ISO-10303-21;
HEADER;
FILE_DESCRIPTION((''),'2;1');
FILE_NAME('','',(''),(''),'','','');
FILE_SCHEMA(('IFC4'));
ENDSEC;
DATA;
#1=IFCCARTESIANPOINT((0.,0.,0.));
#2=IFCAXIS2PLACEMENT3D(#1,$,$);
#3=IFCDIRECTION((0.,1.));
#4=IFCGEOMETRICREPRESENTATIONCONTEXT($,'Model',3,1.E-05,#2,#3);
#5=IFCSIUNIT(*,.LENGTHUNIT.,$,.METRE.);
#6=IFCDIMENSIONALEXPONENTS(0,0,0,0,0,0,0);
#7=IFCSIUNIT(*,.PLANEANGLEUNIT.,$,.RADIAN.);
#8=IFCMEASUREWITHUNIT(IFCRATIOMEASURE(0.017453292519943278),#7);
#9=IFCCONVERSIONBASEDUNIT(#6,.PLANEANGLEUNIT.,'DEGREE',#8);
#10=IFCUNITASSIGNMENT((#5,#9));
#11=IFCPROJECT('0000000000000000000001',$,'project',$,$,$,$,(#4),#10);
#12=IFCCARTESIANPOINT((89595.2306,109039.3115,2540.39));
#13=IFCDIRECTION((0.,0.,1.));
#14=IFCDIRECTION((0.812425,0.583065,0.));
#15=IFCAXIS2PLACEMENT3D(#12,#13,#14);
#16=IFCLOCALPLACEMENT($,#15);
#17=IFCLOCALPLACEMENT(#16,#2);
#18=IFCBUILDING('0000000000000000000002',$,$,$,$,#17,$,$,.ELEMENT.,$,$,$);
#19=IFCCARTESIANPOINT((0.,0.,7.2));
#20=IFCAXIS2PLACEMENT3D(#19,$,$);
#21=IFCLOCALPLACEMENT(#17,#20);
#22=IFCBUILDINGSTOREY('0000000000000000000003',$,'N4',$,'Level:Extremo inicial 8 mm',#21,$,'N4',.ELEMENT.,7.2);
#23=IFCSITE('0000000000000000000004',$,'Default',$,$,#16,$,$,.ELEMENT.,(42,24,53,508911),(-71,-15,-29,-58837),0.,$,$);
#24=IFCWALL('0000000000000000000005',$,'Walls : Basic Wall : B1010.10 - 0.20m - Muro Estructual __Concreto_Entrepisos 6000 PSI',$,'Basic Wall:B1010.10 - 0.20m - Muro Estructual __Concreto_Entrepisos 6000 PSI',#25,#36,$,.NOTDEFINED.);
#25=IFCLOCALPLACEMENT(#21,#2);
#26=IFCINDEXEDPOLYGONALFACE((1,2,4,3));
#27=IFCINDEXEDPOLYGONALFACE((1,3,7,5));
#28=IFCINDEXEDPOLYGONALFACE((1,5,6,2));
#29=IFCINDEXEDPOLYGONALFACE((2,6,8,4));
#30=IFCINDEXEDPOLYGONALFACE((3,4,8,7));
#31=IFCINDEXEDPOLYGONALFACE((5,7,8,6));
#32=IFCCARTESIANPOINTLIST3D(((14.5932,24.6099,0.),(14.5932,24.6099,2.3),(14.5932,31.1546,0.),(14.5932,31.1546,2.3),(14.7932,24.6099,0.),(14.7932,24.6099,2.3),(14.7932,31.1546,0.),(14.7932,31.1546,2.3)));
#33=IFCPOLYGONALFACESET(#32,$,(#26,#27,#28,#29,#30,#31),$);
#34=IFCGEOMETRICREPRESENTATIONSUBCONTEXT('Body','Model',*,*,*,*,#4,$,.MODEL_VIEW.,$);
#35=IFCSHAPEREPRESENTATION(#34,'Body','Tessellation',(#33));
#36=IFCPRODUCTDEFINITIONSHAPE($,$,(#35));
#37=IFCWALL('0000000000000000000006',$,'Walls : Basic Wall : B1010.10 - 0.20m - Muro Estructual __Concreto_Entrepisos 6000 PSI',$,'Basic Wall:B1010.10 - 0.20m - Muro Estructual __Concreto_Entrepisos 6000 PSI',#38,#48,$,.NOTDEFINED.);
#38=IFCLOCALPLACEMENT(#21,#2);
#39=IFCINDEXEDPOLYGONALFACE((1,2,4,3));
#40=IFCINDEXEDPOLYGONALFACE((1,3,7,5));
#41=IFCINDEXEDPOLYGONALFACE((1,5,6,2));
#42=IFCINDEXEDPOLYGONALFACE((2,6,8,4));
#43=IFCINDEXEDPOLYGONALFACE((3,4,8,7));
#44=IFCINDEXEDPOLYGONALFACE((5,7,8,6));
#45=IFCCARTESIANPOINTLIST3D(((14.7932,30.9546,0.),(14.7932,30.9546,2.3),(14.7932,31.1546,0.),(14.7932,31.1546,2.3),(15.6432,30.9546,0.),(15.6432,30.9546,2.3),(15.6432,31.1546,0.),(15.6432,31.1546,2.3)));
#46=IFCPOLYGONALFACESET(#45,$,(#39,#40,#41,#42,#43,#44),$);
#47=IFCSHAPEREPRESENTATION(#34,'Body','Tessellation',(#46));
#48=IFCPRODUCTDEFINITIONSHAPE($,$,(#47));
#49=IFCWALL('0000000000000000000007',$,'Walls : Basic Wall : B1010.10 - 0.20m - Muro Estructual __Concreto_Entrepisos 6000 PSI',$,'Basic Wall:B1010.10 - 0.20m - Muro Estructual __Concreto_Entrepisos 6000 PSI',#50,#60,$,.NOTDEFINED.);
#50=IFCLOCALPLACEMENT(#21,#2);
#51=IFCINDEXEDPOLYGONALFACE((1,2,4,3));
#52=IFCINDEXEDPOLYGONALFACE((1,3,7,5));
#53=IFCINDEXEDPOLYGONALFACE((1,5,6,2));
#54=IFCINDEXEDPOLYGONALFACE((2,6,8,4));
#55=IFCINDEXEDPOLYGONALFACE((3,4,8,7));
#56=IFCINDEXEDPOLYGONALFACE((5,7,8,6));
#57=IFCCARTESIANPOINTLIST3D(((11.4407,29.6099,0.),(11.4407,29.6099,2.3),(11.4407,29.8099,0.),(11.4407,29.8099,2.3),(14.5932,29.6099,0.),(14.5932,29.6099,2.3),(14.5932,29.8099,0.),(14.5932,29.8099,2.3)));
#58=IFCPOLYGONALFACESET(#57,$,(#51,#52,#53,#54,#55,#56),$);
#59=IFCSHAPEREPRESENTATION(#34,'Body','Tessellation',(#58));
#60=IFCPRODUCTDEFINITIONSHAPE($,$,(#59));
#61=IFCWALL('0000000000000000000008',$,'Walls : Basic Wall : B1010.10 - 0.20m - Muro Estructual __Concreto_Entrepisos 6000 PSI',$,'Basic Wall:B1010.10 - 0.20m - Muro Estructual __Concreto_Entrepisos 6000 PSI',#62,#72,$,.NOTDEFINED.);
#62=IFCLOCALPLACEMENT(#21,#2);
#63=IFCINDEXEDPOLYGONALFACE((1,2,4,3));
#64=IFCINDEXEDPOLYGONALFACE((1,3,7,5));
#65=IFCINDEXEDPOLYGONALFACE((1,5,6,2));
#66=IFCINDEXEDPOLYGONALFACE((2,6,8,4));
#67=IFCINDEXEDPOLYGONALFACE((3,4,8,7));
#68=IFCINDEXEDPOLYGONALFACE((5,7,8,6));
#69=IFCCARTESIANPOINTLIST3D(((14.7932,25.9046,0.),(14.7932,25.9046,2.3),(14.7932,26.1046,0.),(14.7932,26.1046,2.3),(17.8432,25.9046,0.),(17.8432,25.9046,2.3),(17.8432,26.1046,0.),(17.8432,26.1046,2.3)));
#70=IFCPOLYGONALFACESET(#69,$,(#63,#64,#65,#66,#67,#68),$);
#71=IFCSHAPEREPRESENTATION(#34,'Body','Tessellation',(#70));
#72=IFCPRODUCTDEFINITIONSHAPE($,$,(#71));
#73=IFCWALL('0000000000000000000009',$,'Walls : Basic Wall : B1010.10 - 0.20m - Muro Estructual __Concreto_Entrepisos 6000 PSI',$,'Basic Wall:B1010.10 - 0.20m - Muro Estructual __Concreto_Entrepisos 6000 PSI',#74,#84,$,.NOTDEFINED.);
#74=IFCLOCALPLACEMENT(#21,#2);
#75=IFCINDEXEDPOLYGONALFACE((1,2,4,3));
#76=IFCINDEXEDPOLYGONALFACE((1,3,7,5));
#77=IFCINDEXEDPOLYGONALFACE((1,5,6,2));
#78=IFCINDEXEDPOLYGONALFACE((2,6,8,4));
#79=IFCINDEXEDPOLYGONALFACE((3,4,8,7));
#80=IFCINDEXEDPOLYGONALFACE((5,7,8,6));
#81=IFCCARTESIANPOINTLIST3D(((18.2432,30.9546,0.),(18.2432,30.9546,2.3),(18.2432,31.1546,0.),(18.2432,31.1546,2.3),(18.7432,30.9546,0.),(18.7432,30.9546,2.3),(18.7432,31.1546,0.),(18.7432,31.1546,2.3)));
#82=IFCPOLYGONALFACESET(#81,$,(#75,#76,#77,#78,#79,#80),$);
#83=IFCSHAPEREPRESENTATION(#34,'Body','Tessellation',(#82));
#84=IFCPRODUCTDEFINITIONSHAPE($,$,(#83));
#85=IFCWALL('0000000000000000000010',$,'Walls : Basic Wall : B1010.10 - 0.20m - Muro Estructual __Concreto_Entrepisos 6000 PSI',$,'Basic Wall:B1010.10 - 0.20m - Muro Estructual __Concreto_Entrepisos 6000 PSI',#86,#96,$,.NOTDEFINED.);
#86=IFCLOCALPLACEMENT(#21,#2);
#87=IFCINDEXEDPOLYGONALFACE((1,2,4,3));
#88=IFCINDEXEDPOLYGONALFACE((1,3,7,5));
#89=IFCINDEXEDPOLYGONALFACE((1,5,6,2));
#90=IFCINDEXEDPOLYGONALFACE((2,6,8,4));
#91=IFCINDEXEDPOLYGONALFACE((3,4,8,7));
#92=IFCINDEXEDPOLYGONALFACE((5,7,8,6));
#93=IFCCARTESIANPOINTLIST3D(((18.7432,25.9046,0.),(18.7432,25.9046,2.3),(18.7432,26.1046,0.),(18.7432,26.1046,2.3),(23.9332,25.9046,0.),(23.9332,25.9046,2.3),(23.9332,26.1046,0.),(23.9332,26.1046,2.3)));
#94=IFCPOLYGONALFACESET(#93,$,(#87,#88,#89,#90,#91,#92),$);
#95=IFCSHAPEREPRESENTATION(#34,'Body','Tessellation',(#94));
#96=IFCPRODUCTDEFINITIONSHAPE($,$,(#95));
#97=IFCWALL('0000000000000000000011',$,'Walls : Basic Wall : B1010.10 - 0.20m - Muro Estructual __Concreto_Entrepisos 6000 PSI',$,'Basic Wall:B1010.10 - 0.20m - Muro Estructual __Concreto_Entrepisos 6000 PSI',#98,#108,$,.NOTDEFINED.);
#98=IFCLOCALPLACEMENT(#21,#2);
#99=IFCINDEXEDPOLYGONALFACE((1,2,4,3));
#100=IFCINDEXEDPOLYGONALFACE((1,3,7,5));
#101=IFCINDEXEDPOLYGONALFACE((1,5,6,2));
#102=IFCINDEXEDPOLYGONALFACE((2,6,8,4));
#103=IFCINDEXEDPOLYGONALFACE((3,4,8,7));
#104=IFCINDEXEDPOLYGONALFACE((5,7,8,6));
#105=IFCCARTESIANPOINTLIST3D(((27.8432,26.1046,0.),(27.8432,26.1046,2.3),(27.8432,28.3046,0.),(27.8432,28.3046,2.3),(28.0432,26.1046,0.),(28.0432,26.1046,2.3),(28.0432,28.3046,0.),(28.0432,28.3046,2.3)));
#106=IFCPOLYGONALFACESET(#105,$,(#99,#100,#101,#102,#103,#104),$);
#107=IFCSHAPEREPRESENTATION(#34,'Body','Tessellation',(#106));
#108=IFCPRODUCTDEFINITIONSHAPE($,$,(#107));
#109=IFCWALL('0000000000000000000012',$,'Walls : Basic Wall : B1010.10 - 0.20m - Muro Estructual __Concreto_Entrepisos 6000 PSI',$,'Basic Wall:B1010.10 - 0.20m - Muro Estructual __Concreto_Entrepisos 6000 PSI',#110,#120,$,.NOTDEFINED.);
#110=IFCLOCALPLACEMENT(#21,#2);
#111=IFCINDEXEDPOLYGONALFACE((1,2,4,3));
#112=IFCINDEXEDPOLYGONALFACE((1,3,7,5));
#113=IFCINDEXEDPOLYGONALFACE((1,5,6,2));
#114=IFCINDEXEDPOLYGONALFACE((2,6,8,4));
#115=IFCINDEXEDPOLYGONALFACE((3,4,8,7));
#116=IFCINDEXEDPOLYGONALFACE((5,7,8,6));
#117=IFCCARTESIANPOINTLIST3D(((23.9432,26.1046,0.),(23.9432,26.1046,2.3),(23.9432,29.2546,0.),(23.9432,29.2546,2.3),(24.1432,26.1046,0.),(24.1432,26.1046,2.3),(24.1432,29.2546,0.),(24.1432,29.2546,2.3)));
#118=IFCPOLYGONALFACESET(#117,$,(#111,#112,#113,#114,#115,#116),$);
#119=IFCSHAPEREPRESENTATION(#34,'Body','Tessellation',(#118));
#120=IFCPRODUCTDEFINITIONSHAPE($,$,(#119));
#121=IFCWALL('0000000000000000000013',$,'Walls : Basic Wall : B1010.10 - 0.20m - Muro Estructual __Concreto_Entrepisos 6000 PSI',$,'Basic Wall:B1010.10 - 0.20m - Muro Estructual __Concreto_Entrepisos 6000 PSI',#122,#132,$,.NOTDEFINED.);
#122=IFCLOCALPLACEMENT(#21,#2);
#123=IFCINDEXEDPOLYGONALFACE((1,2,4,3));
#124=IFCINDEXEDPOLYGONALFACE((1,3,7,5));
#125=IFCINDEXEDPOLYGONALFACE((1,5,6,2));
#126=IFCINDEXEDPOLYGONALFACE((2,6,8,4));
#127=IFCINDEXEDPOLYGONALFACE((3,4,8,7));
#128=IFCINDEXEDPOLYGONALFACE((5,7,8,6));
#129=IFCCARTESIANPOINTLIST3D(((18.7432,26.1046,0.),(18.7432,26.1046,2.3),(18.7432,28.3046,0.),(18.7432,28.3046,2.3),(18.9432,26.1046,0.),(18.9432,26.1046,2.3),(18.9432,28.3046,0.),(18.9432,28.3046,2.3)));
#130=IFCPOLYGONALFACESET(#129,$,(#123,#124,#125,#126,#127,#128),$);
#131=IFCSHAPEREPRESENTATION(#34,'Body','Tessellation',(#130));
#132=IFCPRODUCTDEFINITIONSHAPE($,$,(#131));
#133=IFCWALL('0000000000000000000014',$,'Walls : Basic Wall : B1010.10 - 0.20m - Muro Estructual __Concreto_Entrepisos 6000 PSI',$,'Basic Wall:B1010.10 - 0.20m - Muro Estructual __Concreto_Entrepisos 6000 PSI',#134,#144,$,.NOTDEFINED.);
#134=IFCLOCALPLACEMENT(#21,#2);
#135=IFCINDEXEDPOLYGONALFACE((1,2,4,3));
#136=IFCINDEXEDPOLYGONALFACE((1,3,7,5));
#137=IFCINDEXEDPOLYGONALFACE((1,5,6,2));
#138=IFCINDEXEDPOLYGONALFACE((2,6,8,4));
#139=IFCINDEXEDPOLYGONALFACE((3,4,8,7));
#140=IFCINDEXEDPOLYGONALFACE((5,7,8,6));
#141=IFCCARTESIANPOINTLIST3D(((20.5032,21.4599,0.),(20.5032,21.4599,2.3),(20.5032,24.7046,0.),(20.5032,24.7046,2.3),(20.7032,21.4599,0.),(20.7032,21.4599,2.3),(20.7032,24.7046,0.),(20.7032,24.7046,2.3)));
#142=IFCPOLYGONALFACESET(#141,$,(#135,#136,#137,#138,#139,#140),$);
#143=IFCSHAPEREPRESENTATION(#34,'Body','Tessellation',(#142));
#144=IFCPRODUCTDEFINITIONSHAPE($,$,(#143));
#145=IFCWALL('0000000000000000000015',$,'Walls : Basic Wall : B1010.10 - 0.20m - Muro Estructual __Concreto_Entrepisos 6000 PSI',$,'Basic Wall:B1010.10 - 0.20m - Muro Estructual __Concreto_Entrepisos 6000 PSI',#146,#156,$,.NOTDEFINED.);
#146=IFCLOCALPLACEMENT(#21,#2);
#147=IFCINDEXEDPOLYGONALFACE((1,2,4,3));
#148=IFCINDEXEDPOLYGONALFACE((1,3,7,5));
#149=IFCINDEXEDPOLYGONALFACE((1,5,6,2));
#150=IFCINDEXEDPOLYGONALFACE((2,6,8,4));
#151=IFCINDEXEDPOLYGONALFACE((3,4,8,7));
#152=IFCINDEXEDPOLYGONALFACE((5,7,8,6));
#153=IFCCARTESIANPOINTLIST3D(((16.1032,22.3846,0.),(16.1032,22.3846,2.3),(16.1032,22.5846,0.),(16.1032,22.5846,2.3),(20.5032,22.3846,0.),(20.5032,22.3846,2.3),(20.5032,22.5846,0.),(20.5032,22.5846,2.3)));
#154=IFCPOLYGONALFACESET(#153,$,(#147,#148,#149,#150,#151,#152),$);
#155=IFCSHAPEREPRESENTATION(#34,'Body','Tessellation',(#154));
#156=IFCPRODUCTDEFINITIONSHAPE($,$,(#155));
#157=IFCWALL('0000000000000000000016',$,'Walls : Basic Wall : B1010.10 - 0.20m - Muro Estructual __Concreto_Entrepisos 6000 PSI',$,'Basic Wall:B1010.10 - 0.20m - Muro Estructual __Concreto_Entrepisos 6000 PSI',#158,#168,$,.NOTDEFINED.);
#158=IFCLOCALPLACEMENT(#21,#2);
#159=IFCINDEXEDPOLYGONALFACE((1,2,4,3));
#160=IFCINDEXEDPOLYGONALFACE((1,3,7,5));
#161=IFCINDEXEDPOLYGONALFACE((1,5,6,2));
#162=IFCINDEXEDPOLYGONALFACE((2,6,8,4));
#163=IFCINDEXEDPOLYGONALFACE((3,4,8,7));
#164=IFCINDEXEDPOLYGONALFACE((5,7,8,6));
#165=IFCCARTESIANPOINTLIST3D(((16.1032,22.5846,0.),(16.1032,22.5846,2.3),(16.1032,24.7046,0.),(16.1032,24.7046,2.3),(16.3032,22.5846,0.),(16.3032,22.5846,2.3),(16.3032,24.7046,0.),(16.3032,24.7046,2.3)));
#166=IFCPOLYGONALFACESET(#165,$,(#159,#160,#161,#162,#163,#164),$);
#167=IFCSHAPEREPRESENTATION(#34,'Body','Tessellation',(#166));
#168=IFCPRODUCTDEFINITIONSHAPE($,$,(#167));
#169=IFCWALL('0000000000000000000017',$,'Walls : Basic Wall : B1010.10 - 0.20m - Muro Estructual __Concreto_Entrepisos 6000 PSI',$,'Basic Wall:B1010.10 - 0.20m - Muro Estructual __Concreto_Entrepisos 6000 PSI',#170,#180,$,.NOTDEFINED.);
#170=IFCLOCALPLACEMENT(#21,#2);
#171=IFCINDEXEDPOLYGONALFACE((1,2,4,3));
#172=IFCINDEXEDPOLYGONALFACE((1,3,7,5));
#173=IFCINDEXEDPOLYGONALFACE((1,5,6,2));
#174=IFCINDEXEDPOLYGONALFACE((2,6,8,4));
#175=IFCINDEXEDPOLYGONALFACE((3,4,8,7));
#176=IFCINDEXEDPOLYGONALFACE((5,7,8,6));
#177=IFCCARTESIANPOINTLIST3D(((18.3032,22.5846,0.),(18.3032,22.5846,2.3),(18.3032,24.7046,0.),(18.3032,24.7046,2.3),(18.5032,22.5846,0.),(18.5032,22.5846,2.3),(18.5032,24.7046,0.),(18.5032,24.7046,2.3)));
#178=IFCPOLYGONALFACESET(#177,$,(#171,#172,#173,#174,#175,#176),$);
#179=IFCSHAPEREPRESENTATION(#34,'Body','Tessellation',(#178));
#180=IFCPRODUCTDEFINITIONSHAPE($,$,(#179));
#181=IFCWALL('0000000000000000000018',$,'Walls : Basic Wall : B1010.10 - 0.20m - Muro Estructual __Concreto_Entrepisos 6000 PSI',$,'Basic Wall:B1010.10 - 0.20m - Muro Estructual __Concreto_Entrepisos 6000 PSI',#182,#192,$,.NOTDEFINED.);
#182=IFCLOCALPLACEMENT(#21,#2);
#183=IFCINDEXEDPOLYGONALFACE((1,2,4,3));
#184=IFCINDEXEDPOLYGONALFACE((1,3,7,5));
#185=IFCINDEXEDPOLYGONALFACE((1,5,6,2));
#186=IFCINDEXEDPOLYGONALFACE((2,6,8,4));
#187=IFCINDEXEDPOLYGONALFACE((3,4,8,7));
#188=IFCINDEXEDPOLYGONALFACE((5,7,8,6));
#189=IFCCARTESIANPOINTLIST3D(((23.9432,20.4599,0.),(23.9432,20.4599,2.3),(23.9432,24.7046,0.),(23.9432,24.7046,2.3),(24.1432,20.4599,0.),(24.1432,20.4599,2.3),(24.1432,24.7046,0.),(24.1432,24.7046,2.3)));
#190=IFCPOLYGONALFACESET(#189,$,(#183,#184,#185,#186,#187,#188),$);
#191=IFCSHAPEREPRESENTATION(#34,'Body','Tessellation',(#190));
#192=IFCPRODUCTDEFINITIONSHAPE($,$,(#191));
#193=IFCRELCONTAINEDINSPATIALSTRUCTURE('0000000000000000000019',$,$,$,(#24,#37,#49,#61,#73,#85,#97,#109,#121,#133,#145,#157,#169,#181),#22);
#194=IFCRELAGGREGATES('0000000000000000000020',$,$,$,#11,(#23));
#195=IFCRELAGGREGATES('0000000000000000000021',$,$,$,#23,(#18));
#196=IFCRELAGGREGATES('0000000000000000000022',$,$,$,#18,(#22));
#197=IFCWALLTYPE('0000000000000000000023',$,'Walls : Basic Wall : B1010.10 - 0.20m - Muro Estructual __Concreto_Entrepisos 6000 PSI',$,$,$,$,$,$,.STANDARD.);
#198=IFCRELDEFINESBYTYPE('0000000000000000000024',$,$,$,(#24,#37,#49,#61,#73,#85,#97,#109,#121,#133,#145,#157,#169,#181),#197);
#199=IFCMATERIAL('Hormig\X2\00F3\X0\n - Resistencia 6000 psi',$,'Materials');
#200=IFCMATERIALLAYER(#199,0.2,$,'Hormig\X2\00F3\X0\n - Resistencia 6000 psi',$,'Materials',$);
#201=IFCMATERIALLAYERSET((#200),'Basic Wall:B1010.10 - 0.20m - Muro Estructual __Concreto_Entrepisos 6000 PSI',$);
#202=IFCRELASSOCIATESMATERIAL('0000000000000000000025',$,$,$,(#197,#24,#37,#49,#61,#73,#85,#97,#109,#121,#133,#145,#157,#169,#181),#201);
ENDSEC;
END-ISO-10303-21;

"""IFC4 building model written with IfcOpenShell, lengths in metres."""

from ifc_helpers import new_model, entity, si_unit, converted_unit, direction, frame, frame_2d, origin, place, context, subcontext, project, spatial, rectangle, extrude, material, layer, layer_set, layer_usage, type_object, element, save


model = new_model("IFC4")

# Units and contexts
model_context = context("Model", 3, precision=1e-05, world=origin(), true_north=direction((0.0, 1.0)))
body_context = subcontext(model_context, "Body", "Model", "MODEL_VIEW")
ifc_project = project(units=[si_unit("LENGTHUNIT", "METRE"), converted_unit("PLANEANGLEUNIT", "DEGREE", entity("IfcRatioMeasure", 0.017453292519943278), si_unit("PLANEANGLEUNIT", "RADIAN"), dimensions=[0, 0, 0, 0, 0, 0, 0])], contexts=[model_context])

# Site, building, storey
site_placement = place(None, frame((89595.2306, 109039.3115, 2540.39), z_axis=(0.0, 0.0, 1.0), x_axis=(0.812425, 0.583065, 0.0)))
site = spatial("IfcSite", under=ifc_project, at=site_placement, Name="Default", CompositionType="ELEMENT", RefLatitude=(42, 24, 53, 508911), RefLongitude=(-71, -15, -29, -58837), RefElevation=0.0)
building_placement = place(site_placement, origin())
building = spatial("IfcBuilding", under=site, at=building_placement, CompositionType="ELEMENT")
storey_placement = place(building_placement, frame((0.0, 0.0, 7.2)))
storey = spatial("IfcBuildingStorey", under=building, at=storey_placement, Name="N4", ObjectType="Level:Extremo inicial 8 mm", LongName="N4", CompositionType="ELEMENT", Elevation=7.2)

# Walls
ifc_material_1 = material(Name="Hormigón - Resistencia 6000 psi", Category="Materials")
ifc_layer_1 = layer(ifc_material_1, 0.2, Name="Hormigón - Resistencia 6000 psi", Category="Materials")
ifc_layer_set_1 = layer_set([ifc_layer_1], Name="Basic Wall:B1010.10 - 0.20m - Muro Estructual __Concreto_Entrepisos 6000 PSI")
ifc_layer_usage_1 = layer_usage(ifc_layer_set_1, "AXIS2", "NEGATIVE", 0.1)
wall_type_1 = type_object("IfcWallType", Name="Walls : Basic Wall : B1010.10 - 0.20m - Muro Estructual __Concreto_Entrepisos 6000 PSI", PredefinedType="STANDARD", material=ifc_layer_set_1)
wall_1_placement = place(storey_placement, frame((14.6932, 24.6099, 0.0), z_axis=(0.0, 0.0, 1.0), x_axis=(0.0, 1.0, 0.0)))
element("IfcWall", 1, at=wall_1_placement, inside=storey, type_object=wall_type_1, material=ifc_layer_usage_1, Name="Walls : Basic Wall : B1010.10 - 0.20m - Muro Estructual __Concreto_Entrepisos 6000 PSI", ObjectType="Basic Wall:B1010.10 - 0.20m - Muro Estructual __Concreto_Entrepisos 6000 PSI", PredefinedType="NOTDEFINED", context=body_context, shape_type="SweptSolid", body=[
    extrude(rectangle(XDim=6.5447, YDim=0.2, at=frame_2d((3.2724, 0.0), x_axis=(-1.0, 0.0))), origin(), (0.0, 0.0, 1.0), 2.3),
])
ifc_layer_usage_2 = layer_usage(ifc_layer_set_1, "AXIS2", "NEGATIVE", 0.1)
wall_2_placement = place(storey_placement, frame((15.6432, 31.0546, 0.0), z_axis=(0.0, 0.0, 1.0), x_axis=(-1.0, 0.0, 0.0)))
element("IfcWall", 2, at=wall_2_placement, inside=storey, type_object=wall_type_1, material=ifc_layer_usage_2, Name="Walls : Basic Wall : B1010.10 - 0.20m - Muro Estructual __Concreto_Entrepisos 6000 PSI", ObjectType="Basic Wall:B1010.10 - 0.20m - Muro Estructual __Concreto_Entrepisos 6000 PSI", PredefinedType="NOTDEFINED", context=body_context, shape_type="SweptSolid", body=[
    extrude(rectangle(XDim=0.85, YDim=0.2, at=frame_2d((0.425, 0.0), x_axis=(-1.0, 0.0))), origin(), (0.0, 0.0, 1.0), 2.3),
])
ifc_layer_usage_3 = layer_usage(ifc_layer_set_1, "AXIS2", "NEGATIVE", 0.1)
wall_3_placement = place(storey_placement, frame((11.4407, 29.7099, 0.0)))
element("IfcWall", 3, at=wall_3_placement, inside=storey, type_object=wall_type_1, material=ifc_layer_usage_3, Name="Walls : Basic Wall : B1010.10 - 0.20m - Muro Estructual __Concreto_Entrepisos 6000 PSI", ObjectType="Basic Wall:B1010.10 - 0.20m - Muro Estructual __Concreto_Entrepisos 6000 PSI", PredefinedType="NOTDEFINED", context=body_context, shape_type="SweptSolid", body=[
    extrude(rectangle(XDim=3.1525, YDim=0.2, at=frame_2d((1.5763, 0.0), x_axis=(-1.0, 0.0))), origin(), (0.0, 0.0, 1.0), 2.3),
])
ifc_layer_usage_4 = layer_usage(ifc_layer_set_1, "AXIS2", "NEGATIVE", 0.1)
wall_4_placement = place(storey_placement, frame((17.8432, 26.0046, 0.0), z_axis=(0.0, 0.0, 1.0), x_axis=(-1.0, 0.0, 0.0)))
element("IfcWall", 4, at=wall_4_placement, inside=storey, type_object=wall_type_1, material=ifc_layer_usage_4, Name="Walls : Basic Wall : B1010.10 - 0.20m - Muro Estructual __Concreto_Entrepisos 6000 PSI", ObjectType="Basic Wall:B1010.10 - 0.20m - Muro Estructual __Concreto_Entrepisos 6000 PSI", PredefinedType="NOTDEFINED", context=body_context, shape_type="SweptSolid", body=[
    extrude(rectangle(XDim=3.05, YDim=0.2, at=frame_2d((1.525, 0.0), x_axis=(-1.0, 0.0))), origin(), (0.0, 0.0, 1.0), 2.3),
])
ifc_layer_usage_5 = layer_usage(ifc_layer_set_1, "AXIS2", "NEGATIVE", 0.1)
wall_5_placement = place(storey_placement, frame((18.7432, 31.0546, 0.0), z_axis=(0.0, 0.0, 1.0), x_axis=(-1.0, 0.0, 0.0)))
element("IfcWall", 5, at=wall_5_placement, inside=storey, type_object=wall_type_1, material=ifc_layer_usage_5, Name="Walls : Basic Wall : B1010.10 - 0.20m - Muro Estructual __Concreto_Entrepisos 6000 PSI", ObjectType="Basic Wall:B1010.10 - 0.20m - Muro Estructual __Concreto_Entrepisos 6000 PSI", PredefinedType="NOTDEFINED", context=body_context, shape_type="SweptSolid", body=[
    extrude(rectangle(XDim=0.5, YDim=0.2, at=frame_2d((0.25, 0.0), x_axis=(-1.0, 0.0))), origin(), (0.0, 0.0, 1.0), 2.3),
])
ifc_layer_usage_6 = layer_usage(ifc_layer_set_1, "AXIS2", "NEGATIVE", 0.1)
wall_6_placement = place(storey_placement, frame((18.7432, 26.0046, 0.0)))
element("IfcWall", 6, at=wall_6_placement, inside=storey, type_object=wall_type_1, material=ifc_layer_usage_6, Name="Walls : Basic Wall : B1010.10 - 0.20m - Muro Estructual __Concreto_Entrepisos 6000 PSI", ObjectType="Basic Wall:B1010.10 - 0.20m - Muro Estructual __Concreto_Entrepisos 6000 PSI", PredefinedType="NOTDEFINED", context=body_context, shape_type="SweptSolid", body=[
    extrude(rectangle(XDim=5.19, YDim=0.2, at=frame_2d((2.595, 0.0), x_axis=(-1.0, 0.0))), origin(), (0.0, 0.0, 1.0), 2.3),
])
ifc_layer_usage_7 = layer_usage(ifc_layer_set_1, "AXIS2", "NEGATIVE", 0.1)
wall_7_placement = place(storey_placement, frame((27.9432, 28.3046, 0.0), z_axis=(0.0, 0.0, 1.0), x_axis=(0.0, -1.0, 0.0)))
element("IfcWall", 7, at=wall_7_placement, inside=storey, type_object=wall_type_1, material=ifc_layer_usage_7, Name="Walls : Basic Wall : B1010.10 - 0.20m - Muro Estructual __Concreto_Entrepisos 6000 PSI", ObjectType="Basic Wall:B1010.10 - 0.20m - Muro Estructual __Concreto_Entrepisos 6000 PSI", PredefinedType="NOTDEFINED", context=body_context, shape_type="SweptSolid", body=[
    extrude(rectangle(XDim=2.2, YDim=0.2, at=frame_2d((1.1, 0.0), x_axis=(-1.0, 0.0))), origin(), (0.0, 0.0, 1.0), 2.3),
])
ifc_layer_usage_8 = layer_usage(ifc_layer_set_1, "AXIS2", "NEGATIVE", 0.1)
wall_8_placement = place(storey_placement, frame((24.0432, 26.1046, 0.0), z_axis=(0.0, 0.0, 1.0), x_axis=(0.0, 1.0, 0.0)))
element("IfcWall", 8, at=wall_8_placement, inside=storey, type_object=wall_type_1, material=ifc_layer_usage_8, Name="Walls : Basic Wall : B1010.10 - 0.20m - Muro Estructual __Concreto_Entrepisos 6000 PSI", ObjectType="Basic Wall:B1010.10 - 0.20m - Muro Estructual __Concreto_Entrepisos 6000 PSI", PredefinedType="NOTDEFINED", context=body_context, shape_type="SweptSolid", body=[
    extrude(rectangle(XDim=3.15, YDim=0.2, at=frame_2d((1.575, 0.0), x_axis=(-1.0, 0.0))), origin(), (0.0, 0.0, 1.0), 2.3),
])
ifc_layer_usage_9 = layer_usage(ifc_layer_set_1, "AXIS2", "NEGATIVE", 0.1)
wall_9_placement = place(storey_placement, frame((18.8432, 28.3046, 0.0), z_axis=(0.0, 0.0, 1.0), x_axis=(0.0, -1.0, 0.0)))
element("IfcWall", 9, at=wall_9_placement, inside=storey, type_object=wall_type_1, material=ifc_layer_usage_9, Name="Walls : Basic Wall : B1010.10 - 0.20m - Muro Estructual __Concreto_Entrepisos 6000 PSI", ObjectType="Basic Wall:B1010.10 - 0.20m - Muro Estructual __Concreto_Entrepisos 6000 PSI", PredefinedType="NOTDEFINED", context=body_context, shape_type="SweptSolid", body=[
    extrude(rectangle(XDim=2.2, YDim=0.2, at=frame_2d((1.1, 0.0), x_axis=(-1.0, 0.0))), origin(), (0.0, 0.0, 1.0), 2.3),
])
ifc_layer_usage_10 = layer_usage(ifc_layer_set_1, "AXIS2", "NEGATIVE", 0.1)
wall_10_placement = place(storey_placement, frame((20.6032, 21.4599, 0.0), z_axis=(0.0, 0.0, 1.0), x_axis=(0.0, 1.0, 0.0)))
element("IfcWall", 10, at=wall_10_placement, inside=storey, type_object=wall_type_1, material=ifc_layer_usage_10, Name="Walls : Basic Wall : B1010.10 - 0.20m - Muro Estructual __Concreto_Entrepisos 6000 PSI", ObjectType="Basic Wall:B1010.10 - 0.20m - Muro Estructual __Concreto_Entrepisos 6000 PSI", PredefinedType="NOTDEFINED", context=body_context, shape_type="SweptSolid", body=[
    extrude(rectangle(XDim=3.2447, YDim=0.2, at=frame_2d((1.6224, 0.0), x_axis=(-1.0, 0.0))), origin(), (0.0, 0.0, 1.0), 2.3),
])
ifc_layer_usage_11 = layer_usage(ifc_layer_set_1, "AXIS2", "NEGATIVE", 0.1)
wall_11_placement = place(storey_placement, frame((20.5032, 22.4846, 0.0), z_axis=(0.0, 0.0, 1.0), x_axis=(-1.0, 0.0, 0.0)))
element("IfcWall", 11, at=wall_11_placement, inside=storey, type_object=wall_type_1, material=ifc_layer_usage_11, Name="Walls : Basic Wall : B1010.10 - 0.20m - Muro Estructual __Concreto_Entrepisos 6000 PSI", ObjectType="Basic Wall:B1010.10 - 0.20m - Muro Estructual __Concreto_Entrepisos 6000 PSI", PredefinedType="NOTDEFINED", context=body_context, shape_type="SweptSolid", body=[
    extrude(rectangle(XDim=4.4, YDim=0.2, at=frame_2d((2.2, 0.0), x_axis=(-1.0, 0.0))), origin(), (0.0, 0.0, 1.0), 2.3),
])
ifc_layer_usage_12 = layer_usage(ifc_layer_set_1, "AXIS2", "NEGATIVE", 0.1)
wall_12_placement = place(storey_placement, frame((16.2032, 22.5846, 0.0), z_axis=(0.0, 0.0, 1.0), x_axis=(0.0, 1.0, 0.0)))
element("IfcWall", 12, at=wall_12_placement, inside=storey, type_object=wall_type_1, material=ifc_layer_usage_12, Name="Walls : Basic Wall : B1010.10 - 0.20m - Muro Estructual __Concreto_Entrepisos 6000 PSI", ObjectType="Basic Wall:B1010.10 - 0.20m - Muro Estructual __Concreto_Entrepisos 6000 PSI", PredefinedType="NOTDEFINED", context=body_context, shape_type="SweptSolid", body=[
    extrude(rectangle(XDim=2.12, YDim=0.2, at=frame_2d((1.06, 0.0), x_axis=(-1.0, 0.0))), origin(), (0.0, 0.0, 1.0), 2.3),
])
ifc_layer_usage_13 = layer_usage(ifc_layer_set_1, "AXIS2", "NEGATIVE", 0.1)
wall_13_placement = place(storey_placement, frame((18.4032, 24.7046, 0.0), z_axis=(0.0, 0.0, 1.0), x_axis=(0.0, -1.0, 0.0)))
element("IfcWall", 13, at=wall_13_placement, inside=storey, type_object=wall_type_1, material=ifc_layer_usage_13, Name="Walls : Basic Wall : B1010.10 - 0.20m - Muro Estructual __Concreto_Entrepisos 6000 PSI", ObjectType="Basic Wall:B1010.10 - 0.20m - Muro Estructual __Concreto_Entrepisos 6000 PSI", PredefinedType="NOTDEFINED", context=body_context, shape_type="SweptSolid", body=[
    extrude(rectangle(XDim=2.12, YDim=0.2, at=frame_2d((1.06, 0.0), x_axis=(-1.0, 0.0))), origin(), (0.0, 0.0, 1.0), 2.3),
])
ifc_layer_usage_14 = layer_usage(ifc_layer_set_1, "AXIS2", "NEGATIVE", 0.1)
wall_14_placement = place(storey_placement, frame((24.0432, 20.4599, 0.0), z_axis=(0.0, 0.0, 1.0), x_axis=(0.0, 1.0, 0.0)))
element("IfcWall", 14, at=wall_14_placement, inside=storey, type_object=wall_type_1, material=ifc_layer_usage_14, Name="Walls : Basic Wall : B1010.10 - 0.20m - Muro Estructual __Concreto_Entrepisos 6000 PSI", ObjectType="Basic Wall:B1010.10 - 0.20m - Muro Estructual __Concreto_Entrepisos 6000 PSI", PredefinedType="NOTDEFINED", context=body_context, shape_type="SweptSolid", body=[
    extrude(rectangle(XDim=4.2447, YDim=0.2, at=frame_2d((2.1224, 0.0), x_axis=(-1.0, 0.0))), origin(), (0.0, 0.0, 1.0), 2.3),
])

save(model, "model.ifc")
